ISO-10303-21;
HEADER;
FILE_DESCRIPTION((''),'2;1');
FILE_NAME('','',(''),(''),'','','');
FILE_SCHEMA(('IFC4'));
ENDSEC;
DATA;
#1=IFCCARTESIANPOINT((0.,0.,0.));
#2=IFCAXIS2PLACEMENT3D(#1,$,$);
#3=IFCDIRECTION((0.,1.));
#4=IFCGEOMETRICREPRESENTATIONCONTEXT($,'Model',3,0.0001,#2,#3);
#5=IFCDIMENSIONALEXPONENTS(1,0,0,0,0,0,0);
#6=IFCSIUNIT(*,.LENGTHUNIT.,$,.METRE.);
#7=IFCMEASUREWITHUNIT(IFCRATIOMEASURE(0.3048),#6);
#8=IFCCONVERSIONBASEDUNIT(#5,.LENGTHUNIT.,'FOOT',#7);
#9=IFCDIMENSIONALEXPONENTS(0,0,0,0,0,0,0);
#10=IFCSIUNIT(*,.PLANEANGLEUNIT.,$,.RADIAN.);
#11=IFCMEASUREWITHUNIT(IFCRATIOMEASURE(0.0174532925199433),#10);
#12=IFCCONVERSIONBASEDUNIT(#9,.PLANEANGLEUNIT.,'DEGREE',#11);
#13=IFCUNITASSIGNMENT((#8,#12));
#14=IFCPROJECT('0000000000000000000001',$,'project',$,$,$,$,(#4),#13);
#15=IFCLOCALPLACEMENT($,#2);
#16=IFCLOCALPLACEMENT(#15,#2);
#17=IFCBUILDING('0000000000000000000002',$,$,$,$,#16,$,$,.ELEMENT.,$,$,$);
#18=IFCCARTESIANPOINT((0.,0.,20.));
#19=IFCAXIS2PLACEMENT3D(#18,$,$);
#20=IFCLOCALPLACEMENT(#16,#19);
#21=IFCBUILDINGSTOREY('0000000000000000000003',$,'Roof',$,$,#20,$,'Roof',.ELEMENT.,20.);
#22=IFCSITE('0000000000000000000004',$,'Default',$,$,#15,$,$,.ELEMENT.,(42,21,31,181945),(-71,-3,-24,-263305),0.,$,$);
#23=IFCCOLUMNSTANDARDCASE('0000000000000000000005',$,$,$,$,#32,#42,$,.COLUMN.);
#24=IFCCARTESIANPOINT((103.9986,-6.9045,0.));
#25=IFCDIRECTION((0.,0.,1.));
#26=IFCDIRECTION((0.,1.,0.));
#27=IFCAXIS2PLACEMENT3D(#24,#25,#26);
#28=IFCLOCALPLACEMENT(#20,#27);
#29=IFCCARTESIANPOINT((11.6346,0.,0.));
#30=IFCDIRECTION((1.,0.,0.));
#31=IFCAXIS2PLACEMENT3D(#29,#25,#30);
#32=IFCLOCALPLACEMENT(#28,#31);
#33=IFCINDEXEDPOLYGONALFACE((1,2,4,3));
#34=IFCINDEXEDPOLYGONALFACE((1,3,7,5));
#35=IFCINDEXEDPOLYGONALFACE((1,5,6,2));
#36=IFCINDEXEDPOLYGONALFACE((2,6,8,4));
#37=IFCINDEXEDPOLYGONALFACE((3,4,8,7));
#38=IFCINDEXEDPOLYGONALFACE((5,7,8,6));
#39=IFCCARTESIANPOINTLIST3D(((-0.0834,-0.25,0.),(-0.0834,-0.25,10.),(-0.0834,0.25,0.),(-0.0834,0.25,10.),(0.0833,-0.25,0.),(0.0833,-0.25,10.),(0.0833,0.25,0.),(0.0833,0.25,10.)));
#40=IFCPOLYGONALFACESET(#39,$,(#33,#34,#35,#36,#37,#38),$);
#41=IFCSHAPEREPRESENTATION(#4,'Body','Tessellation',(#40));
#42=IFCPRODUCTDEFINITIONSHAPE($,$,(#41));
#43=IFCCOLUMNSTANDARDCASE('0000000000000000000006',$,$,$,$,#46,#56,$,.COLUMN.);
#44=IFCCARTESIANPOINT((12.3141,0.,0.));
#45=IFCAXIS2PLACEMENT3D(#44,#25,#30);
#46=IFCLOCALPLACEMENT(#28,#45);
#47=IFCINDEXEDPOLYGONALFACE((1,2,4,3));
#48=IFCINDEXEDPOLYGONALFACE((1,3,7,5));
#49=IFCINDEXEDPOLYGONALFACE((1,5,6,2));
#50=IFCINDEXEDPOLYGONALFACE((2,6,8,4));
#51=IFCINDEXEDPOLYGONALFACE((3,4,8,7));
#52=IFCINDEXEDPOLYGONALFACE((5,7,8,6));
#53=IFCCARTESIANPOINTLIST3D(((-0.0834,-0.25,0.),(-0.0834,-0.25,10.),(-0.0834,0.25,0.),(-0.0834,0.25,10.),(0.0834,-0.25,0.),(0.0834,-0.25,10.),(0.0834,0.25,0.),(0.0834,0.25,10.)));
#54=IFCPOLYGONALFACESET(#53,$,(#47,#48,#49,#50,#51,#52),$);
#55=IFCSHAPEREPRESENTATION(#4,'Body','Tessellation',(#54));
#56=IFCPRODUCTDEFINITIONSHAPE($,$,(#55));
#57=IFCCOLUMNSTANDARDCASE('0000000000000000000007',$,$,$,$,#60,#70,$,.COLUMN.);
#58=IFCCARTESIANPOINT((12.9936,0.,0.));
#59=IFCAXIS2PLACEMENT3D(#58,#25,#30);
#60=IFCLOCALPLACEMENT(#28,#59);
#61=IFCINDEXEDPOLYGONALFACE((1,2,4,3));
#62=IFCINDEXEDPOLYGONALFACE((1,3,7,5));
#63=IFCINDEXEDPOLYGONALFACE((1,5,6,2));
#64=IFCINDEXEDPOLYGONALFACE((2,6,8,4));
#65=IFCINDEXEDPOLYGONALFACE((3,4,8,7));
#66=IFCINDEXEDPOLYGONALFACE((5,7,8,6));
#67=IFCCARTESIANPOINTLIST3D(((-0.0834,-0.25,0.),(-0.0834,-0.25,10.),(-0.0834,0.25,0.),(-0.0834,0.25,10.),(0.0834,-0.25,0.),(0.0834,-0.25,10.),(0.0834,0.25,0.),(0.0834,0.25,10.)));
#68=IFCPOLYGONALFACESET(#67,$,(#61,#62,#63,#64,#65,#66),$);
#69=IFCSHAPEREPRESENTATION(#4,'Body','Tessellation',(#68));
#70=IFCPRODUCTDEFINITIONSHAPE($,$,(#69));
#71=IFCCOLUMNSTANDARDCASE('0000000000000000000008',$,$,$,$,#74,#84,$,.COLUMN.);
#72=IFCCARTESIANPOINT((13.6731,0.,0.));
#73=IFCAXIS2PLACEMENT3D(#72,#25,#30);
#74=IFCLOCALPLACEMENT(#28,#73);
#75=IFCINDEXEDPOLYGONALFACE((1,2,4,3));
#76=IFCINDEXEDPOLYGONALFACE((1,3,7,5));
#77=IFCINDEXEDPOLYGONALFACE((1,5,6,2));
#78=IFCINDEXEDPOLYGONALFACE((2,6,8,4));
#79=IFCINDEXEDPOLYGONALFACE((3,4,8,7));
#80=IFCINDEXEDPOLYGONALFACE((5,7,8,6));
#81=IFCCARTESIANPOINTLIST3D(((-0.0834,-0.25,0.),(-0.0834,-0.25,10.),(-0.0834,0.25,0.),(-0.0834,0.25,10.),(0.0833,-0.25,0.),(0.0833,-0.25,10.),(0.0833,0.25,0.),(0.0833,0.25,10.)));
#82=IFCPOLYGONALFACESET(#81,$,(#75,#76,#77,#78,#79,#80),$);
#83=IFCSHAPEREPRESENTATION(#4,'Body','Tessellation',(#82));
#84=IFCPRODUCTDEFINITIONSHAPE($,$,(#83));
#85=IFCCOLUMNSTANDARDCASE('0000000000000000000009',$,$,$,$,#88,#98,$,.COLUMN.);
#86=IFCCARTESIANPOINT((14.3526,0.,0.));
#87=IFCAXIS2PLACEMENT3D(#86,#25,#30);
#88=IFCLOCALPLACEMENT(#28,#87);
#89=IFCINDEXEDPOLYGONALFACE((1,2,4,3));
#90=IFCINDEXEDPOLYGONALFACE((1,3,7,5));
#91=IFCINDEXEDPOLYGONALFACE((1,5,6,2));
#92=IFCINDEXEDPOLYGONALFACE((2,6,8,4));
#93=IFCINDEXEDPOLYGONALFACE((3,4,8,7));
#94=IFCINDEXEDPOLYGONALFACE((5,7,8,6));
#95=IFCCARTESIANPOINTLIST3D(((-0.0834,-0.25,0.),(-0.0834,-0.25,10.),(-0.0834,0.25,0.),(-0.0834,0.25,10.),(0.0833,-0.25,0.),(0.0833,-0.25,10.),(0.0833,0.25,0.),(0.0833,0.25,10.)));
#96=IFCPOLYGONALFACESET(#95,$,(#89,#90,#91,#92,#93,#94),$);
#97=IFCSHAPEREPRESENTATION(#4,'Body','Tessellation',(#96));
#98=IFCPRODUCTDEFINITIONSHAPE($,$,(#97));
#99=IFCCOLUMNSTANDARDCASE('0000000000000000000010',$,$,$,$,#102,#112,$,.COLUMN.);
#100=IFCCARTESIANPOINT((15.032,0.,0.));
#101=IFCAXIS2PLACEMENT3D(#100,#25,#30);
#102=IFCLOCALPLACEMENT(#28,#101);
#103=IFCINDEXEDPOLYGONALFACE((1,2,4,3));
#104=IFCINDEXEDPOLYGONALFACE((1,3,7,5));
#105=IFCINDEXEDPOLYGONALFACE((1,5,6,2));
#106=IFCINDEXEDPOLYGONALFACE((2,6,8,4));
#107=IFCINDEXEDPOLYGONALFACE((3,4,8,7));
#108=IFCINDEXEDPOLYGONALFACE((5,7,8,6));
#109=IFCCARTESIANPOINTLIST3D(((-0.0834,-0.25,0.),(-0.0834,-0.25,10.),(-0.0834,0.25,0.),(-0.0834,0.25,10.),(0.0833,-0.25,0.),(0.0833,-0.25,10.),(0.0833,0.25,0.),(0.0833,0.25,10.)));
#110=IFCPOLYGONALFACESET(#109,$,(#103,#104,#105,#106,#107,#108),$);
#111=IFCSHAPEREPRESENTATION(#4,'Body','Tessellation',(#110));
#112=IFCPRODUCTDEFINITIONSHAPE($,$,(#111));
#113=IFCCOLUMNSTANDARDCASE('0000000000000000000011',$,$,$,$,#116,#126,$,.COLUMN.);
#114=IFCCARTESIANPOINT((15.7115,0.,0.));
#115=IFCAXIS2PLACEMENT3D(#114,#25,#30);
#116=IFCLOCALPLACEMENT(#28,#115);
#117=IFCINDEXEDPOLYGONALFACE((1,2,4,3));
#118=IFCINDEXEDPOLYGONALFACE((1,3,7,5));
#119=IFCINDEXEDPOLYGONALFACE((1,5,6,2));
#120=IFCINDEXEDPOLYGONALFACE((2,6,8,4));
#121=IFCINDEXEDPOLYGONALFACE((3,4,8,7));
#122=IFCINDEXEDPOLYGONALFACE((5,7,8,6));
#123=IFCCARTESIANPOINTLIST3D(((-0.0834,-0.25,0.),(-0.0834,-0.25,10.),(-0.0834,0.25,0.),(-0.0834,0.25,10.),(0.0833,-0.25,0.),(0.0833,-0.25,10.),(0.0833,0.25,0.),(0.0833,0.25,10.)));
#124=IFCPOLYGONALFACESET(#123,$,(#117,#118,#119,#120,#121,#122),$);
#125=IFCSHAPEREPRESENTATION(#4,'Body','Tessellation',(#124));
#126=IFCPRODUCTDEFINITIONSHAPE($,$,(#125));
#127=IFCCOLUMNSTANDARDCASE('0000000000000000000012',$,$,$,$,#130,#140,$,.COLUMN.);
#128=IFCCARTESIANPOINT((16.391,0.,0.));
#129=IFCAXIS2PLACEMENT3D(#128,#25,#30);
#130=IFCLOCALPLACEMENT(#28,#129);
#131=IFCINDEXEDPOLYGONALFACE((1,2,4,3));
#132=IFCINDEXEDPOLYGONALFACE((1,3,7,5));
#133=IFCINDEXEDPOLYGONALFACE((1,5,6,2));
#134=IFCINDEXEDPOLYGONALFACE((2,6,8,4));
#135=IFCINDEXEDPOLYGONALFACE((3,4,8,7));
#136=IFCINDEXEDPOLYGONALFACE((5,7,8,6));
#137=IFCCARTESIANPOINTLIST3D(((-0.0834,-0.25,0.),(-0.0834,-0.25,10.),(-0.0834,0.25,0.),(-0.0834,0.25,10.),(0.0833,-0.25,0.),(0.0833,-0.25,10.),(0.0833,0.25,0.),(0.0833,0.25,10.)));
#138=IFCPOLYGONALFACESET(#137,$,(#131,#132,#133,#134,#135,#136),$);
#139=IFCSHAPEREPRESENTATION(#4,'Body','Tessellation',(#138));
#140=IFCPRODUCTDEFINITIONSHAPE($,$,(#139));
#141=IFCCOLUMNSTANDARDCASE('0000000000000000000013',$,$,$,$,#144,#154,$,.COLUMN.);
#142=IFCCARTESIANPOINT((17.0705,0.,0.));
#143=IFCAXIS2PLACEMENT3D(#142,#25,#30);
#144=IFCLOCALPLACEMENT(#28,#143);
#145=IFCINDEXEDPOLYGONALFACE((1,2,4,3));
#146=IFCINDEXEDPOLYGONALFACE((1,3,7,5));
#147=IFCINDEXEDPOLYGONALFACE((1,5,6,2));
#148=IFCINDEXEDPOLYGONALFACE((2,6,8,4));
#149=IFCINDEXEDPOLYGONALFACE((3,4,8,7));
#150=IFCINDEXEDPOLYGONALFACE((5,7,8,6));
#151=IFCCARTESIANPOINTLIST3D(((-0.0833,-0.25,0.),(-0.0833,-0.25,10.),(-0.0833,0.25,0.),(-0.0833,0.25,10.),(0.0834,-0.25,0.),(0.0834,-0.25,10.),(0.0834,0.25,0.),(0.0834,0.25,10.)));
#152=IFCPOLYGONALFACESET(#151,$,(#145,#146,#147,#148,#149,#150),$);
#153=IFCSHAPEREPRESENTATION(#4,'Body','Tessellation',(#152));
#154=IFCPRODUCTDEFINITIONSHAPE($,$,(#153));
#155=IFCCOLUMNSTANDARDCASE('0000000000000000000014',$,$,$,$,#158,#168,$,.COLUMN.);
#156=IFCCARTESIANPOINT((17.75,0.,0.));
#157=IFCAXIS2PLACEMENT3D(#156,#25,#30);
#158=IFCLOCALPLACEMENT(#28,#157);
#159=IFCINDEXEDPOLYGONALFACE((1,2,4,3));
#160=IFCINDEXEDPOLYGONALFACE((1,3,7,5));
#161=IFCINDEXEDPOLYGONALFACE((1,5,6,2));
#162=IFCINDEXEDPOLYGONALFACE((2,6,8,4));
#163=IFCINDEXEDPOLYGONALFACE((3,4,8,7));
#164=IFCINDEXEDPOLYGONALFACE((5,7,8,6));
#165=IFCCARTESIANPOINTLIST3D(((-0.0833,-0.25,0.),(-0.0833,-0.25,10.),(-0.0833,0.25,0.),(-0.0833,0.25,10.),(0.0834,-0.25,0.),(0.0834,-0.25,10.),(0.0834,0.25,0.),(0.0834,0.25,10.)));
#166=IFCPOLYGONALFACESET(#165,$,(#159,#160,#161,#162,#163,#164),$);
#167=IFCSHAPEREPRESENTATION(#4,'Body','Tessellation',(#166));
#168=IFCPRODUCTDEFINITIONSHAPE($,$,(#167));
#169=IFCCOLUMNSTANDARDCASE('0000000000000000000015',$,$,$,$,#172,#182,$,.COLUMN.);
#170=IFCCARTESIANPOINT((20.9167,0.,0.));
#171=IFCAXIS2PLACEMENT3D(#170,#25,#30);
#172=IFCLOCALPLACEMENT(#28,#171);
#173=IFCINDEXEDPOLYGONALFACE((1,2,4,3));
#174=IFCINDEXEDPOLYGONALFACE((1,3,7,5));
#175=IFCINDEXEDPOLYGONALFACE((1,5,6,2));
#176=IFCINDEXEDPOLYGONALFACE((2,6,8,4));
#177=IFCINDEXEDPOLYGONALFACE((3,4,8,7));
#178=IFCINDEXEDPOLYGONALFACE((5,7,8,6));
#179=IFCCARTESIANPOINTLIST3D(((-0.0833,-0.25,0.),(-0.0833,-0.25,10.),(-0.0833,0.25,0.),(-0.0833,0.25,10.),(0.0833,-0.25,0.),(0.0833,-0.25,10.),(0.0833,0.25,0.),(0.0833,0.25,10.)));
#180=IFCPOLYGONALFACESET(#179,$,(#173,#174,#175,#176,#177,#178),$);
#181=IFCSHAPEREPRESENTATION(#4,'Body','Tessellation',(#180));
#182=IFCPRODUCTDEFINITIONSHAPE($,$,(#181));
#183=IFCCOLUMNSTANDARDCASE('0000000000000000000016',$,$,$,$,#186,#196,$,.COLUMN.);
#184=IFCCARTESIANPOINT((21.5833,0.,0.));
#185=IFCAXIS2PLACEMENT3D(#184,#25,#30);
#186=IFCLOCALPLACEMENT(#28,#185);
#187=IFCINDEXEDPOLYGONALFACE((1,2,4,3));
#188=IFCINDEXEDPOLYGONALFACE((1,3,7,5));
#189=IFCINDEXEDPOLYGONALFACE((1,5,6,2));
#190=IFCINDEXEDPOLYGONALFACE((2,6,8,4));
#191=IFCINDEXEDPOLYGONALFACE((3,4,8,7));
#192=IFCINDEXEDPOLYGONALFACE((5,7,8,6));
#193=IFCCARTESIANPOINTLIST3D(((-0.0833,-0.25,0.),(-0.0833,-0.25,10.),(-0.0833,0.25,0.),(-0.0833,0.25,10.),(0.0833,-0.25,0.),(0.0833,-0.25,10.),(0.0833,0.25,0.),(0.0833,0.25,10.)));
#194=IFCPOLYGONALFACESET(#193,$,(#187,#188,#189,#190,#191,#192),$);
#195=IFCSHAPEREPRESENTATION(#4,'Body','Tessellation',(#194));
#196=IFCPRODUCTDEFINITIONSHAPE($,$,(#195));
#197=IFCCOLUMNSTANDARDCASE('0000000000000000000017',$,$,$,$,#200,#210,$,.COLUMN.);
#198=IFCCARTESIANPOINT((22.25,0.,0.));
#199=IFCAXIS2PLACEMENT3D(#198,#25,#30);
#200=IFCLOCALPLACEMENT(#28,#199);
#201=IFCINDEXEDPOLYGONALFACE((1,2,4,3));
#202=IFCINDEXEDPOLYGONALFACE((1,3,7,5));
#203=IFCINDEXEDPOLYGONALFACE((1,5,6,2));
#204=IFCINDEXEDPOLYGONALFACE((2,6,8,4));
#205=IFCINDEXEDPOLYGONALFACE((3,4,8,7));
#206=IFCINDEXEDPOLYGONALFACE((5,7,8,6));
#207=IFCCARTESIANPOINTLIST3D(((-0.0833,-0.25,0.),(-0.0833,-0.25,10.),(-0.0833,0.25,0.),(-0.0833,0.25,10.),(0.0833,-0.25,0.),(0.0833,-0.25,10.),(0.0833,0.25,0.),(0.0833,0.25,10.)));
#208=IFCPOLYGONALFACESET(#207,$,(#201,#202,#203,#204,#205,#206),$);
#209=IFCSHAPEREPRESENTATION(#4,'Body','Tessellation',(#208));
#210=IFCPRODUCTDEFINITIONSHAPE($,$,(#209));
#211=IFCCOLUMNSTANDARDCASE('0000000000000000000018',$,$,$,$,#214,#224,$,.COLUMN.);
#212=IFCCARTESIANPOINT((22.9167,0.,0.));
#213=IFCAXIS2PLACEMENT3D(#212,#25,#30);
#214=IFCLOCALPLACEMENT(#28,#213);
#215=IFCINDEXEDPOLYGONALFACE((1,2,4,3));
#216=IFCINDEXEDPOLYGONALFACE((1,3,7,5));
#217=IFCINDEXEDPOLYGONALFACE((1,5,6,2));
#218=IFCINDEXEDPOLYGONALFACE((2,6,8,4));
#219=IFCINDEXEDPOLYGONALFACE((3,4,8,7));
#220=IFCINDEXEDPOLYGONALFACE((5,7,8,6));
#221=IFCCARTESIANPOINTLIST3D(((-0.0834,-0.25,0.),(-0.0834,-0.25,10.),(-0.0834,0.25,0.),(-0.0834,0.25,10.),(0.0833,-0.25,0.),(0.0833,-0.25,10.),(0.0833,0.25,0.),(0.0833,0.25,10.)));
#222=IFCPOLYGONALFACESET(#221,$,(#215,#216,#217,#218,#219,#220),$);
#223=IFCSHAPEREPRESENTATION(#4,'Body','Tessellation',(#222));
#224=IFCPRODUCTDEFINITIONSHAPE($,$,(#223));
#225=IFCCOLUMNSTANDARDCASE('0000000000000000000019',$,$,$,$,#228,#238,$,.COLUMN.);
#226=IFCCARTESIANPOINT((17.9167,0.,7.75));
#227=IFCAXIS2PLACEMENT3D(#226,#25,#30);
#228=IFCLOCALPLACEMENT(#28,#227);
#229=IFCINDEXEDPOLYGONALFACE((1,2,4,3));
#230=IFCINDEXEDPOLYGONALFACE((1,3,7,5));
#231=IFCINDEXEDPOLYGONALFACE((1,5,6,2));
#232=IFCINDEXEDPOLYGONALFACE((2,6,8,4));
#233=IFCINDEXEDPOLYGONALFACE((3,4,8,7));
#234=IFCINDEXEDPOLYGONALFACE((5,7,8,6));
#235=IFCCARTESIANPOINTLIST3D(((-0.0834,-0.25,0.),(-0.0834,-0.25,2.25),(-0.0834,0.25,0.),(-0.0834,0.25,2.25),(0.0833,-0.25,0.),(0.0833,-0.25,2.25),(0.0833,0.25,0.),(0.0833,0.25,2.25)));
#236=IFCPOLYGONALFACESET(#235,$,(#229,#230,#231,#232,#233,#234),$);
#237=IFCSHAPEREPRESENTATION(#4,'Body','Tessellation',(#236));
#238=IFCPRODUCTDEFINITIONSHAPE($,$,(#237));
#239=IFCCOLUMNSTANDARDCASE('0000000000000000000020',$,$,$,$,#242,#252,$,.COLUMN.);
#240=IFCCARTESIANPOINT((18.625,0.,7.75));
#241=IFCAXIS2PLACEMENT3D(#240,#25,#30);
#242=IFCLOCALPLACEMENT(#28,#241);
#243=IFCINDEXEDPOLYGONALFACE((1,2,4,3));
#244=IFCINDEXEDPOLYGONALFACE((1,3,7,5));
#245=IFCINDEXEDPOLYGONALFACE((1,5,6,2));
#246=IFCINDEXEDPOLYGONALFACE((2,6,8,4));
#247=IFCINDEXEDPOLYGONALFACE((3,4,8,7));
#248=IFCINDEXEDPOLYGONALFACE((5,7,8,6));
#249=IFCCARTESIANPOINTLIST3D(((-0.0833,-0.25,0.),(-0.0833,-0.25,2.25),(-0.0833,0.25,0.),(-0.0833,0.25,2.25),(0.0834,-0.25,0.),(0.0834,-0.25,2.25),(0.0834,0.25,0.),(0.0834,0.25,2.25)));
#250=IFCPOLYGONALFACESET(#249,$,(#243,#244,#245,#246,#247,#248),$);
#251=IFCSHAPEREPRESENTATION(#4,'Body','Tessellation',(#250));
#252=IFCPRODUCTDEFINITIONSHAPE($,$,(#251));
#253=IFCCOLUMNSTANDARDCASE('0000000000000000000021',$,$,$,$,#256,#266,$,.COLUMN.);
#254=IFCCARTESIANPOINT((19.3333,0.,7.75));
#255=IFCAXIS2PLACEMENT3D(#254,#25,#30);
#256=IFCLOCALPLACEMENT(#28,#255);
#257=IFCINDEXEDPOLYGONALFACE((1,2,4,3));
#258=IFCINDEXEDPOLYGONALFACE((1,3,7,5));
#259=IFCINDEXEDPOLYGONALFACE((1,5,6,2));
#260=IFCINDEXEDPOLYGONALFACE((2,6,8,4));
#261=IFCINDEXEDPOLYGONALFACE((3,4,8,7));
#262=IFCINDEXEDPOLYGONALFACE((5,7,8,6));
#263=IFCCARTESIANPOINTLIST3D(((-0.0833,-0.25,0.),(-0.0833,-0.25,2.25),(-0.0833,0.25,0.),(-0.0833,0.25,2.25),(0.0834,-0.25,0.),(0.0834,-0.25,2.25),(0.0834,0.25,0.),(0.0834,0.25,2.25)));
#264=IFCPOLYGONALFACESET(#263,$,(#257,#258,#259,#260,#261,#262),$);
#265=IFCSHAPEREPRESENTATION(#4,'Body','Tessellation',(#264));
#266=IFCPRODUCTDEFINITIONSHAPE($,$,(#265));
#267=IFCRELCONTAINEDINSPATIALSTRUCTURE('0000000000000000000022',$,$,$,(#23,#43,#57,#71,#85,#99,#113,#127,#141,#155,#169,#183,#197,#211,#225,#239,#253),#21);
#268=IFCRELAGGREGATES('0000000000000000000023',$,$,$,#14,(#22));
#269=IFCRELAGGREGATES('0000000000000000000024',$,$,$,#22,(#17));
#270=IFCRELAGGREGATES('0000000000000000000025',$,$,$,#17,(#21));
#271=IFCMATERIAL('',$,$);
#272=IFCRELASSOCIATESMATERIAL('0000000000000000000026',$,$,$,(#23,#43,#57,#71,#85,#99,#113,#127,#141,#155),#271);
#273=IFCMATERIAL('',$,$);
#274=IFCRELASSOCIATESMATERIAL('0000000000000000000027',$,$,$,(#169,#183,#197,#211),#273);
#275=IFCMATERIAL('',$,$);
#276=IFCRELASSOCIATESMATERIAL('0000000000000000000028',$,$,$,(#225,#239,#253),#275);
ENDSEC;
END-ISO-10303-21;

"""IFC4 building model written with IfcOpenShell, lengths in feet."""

from ifc_helpers import new_model, entity, si_unit, converted_unit, direction, frame, origin, place, context, project, spatial, rectangle, extrude, material, element, save


model = new_model("IFC4")

# Units and contexts
model_context = context("Model", 3, precision=0.0001, world=origin(), true_north=direction((0.0, 1.0)))
ifc_project = project(units=[converted_unit("LENGTHUNIT", "FOOT", entity("IfcRatioMeasure", 0.3048), si_unit("LENGTHUNIT", "METRE"), dimensions=[1, 0, 0, 0, 0, 0, 0]), converted_unit("PLANEANGLEUNIT", "DEGREE", entity("IfcRatioMeasure", 0.0174532925199433), si_unit("PLANEANGLEUNIT", "RADIAN"), dimensions=[0, 0, 0, 0, 0, 0, 0])], contexts=[model_context])

# Site, building, storey
site_placement = place(None, origin())
site = spatial("IfcSite", under=ifc_project, at=site_placement, Name="Default", CompositionType="ELEMENT", RefLatitude=(42, 21, 31, 181945), RefLongitude=(-71, -3, -24, -263305), RefElevation=0.0)
building_placement = place(site_placement, origin())
building = spatial("IfcBuilding", under=site, at=building_placement, CompositionType="ELEMENT")
storey_placement = place(building_placement, frame((0.0, 0.0, 20.0)))
storey = spatial("IfcBuildingStorey", under=building, at=storey_placement, Name="Roof", LongName="Roof", CompositionType="ELEMENT", Elevation=20.0)

# Columns
ifc_material_1 = material(Name="")
placement = place(storey_placement, frame((103.9986, -6.9045, 0.0), z_axis=(0.0, 0.0, 1.0), x_axis=(0.0, 1.0, 0.0)))
for number, where, z_axis, x_axis in (
    (1, (11.6346, 0.0, 0.0), (0.0, 0.0, 1.0), (1.0, 0.0, 0.0)),
    (2, (12.3141, 0.0, 0.0), (0.0, 0.0, 1.0), (1.0, 0.0, 0.0)),
    (3, (12.9936, 0.0, 0.0), (0.0, 0.0, 1.0), (1.0, 0.0, 0.0)),
    (4, (13.6731, 0.0, 0.0), (0.0, 0.0, 1.0), (1.0, 0.0, 0.0)),
    (5, (14.3526, 0.0, 0.0), (0.0, 0.0, 1.0), (1.0, 0.0, 0.0)),
    (6, (15.032, 0.0, 0.0), (0.0, 0.0, 1.0), (1.0, 0.0, 0.0)),
    (7, (15.7115, 0.0, 0.0), (0.0, 0.0, 1.0), (1.0, 0.0, 0.0)),
    (8, (16.391, 0.0, 0.0), (0.0, 0.0, 1.0), (1.0, 0.0, 0.0)),
    (9, (17.0705, 0.0, 0.0), (0.0, 0.0, 1.0), (1.0, 0.0, 0.0)),
    (10, (17.75, 0.0, 0.0), (0.0, 0.0, 1.0), (1.0, 0.0, 0.0)),
):
    element("IfcColumnStandardCase", number, at=place(placement, frame(where, z_axis=z_axis, x_axis=x_axis)), inside=storey, material=ifc_material_1, PredefinedType="COLUMN", context=model_context, shape_type="SweptSolid", body=[
        extrude(rectangle(XDim=0.1667, YDim=0.5), origin(), (0.0, 0.0, 1.0), 10.0),
    ])
ifc_material_2 = material(Name="")
for number, where, z_axis, x_axis in (
    (11, (20.9167, 0.0, 0.0), (0.0, 0.0, 1.0), (1.0, 0.0, 0.0)),
    (12, (21.5833, 0.0, 0.0), (0.0, 0.0, 1.0), (1.0, 0.0, 0.0)),
    (13, (22.25, 0.0, 0.0), (0.0, 0.0, 1.0), (1.0, 0.0, 0.0)),
    (14, (22.9167, 0.0, 0.0), (0.0, 0.0, 1.0), (1.0, 0.0, 0.0)),
):
    element("IfcColumnStandardCase", number, at=place(placement, frame(where, z_axis=z_axis, x_axis=x_axis)), inside=storey, material=ifc_material_2, PredefinedType="COLUMN", context=model_context, shape_type="SweptSolid", body=[
        extrude(rectangle(XDim=0.1667, YDim=0.5), origin(), (0.0, 0.0, 1.0), 10.0),
    ])
ifc_material_3 = material(Name="")
for number, where, z_axis, x_axis in (
    (15, (17.9167, 0.0, 7.75), (0.0, 0.0, 1.0), (1.0, 0.0, 0.0)),
    (16, (18.625, 0.0, 7.75), (0.0, 0.0, 1.0), (1.0, 0.0, 0.0)),
    (17, (19.3333, 0.0, 7.75), (0.0, 0.0, 1.0), (1.0, 0.0, 0.0)),
):
    element("IfcColumnStandardCase", number, at=place(placement, frame(where, z_axis=z_axis, x_axis=x_axis)), inside=storey, material=ifc_material_3, PredefinedType="COLUMN", context=model_context, shape_type="SweptSolid", body=[
        extrude(rectangle(XDim=0.1667, YDim=0.5), origin(), (0.0, 0.0, 1.0), 2.25),
    ])

save(model, "model.ifc")
